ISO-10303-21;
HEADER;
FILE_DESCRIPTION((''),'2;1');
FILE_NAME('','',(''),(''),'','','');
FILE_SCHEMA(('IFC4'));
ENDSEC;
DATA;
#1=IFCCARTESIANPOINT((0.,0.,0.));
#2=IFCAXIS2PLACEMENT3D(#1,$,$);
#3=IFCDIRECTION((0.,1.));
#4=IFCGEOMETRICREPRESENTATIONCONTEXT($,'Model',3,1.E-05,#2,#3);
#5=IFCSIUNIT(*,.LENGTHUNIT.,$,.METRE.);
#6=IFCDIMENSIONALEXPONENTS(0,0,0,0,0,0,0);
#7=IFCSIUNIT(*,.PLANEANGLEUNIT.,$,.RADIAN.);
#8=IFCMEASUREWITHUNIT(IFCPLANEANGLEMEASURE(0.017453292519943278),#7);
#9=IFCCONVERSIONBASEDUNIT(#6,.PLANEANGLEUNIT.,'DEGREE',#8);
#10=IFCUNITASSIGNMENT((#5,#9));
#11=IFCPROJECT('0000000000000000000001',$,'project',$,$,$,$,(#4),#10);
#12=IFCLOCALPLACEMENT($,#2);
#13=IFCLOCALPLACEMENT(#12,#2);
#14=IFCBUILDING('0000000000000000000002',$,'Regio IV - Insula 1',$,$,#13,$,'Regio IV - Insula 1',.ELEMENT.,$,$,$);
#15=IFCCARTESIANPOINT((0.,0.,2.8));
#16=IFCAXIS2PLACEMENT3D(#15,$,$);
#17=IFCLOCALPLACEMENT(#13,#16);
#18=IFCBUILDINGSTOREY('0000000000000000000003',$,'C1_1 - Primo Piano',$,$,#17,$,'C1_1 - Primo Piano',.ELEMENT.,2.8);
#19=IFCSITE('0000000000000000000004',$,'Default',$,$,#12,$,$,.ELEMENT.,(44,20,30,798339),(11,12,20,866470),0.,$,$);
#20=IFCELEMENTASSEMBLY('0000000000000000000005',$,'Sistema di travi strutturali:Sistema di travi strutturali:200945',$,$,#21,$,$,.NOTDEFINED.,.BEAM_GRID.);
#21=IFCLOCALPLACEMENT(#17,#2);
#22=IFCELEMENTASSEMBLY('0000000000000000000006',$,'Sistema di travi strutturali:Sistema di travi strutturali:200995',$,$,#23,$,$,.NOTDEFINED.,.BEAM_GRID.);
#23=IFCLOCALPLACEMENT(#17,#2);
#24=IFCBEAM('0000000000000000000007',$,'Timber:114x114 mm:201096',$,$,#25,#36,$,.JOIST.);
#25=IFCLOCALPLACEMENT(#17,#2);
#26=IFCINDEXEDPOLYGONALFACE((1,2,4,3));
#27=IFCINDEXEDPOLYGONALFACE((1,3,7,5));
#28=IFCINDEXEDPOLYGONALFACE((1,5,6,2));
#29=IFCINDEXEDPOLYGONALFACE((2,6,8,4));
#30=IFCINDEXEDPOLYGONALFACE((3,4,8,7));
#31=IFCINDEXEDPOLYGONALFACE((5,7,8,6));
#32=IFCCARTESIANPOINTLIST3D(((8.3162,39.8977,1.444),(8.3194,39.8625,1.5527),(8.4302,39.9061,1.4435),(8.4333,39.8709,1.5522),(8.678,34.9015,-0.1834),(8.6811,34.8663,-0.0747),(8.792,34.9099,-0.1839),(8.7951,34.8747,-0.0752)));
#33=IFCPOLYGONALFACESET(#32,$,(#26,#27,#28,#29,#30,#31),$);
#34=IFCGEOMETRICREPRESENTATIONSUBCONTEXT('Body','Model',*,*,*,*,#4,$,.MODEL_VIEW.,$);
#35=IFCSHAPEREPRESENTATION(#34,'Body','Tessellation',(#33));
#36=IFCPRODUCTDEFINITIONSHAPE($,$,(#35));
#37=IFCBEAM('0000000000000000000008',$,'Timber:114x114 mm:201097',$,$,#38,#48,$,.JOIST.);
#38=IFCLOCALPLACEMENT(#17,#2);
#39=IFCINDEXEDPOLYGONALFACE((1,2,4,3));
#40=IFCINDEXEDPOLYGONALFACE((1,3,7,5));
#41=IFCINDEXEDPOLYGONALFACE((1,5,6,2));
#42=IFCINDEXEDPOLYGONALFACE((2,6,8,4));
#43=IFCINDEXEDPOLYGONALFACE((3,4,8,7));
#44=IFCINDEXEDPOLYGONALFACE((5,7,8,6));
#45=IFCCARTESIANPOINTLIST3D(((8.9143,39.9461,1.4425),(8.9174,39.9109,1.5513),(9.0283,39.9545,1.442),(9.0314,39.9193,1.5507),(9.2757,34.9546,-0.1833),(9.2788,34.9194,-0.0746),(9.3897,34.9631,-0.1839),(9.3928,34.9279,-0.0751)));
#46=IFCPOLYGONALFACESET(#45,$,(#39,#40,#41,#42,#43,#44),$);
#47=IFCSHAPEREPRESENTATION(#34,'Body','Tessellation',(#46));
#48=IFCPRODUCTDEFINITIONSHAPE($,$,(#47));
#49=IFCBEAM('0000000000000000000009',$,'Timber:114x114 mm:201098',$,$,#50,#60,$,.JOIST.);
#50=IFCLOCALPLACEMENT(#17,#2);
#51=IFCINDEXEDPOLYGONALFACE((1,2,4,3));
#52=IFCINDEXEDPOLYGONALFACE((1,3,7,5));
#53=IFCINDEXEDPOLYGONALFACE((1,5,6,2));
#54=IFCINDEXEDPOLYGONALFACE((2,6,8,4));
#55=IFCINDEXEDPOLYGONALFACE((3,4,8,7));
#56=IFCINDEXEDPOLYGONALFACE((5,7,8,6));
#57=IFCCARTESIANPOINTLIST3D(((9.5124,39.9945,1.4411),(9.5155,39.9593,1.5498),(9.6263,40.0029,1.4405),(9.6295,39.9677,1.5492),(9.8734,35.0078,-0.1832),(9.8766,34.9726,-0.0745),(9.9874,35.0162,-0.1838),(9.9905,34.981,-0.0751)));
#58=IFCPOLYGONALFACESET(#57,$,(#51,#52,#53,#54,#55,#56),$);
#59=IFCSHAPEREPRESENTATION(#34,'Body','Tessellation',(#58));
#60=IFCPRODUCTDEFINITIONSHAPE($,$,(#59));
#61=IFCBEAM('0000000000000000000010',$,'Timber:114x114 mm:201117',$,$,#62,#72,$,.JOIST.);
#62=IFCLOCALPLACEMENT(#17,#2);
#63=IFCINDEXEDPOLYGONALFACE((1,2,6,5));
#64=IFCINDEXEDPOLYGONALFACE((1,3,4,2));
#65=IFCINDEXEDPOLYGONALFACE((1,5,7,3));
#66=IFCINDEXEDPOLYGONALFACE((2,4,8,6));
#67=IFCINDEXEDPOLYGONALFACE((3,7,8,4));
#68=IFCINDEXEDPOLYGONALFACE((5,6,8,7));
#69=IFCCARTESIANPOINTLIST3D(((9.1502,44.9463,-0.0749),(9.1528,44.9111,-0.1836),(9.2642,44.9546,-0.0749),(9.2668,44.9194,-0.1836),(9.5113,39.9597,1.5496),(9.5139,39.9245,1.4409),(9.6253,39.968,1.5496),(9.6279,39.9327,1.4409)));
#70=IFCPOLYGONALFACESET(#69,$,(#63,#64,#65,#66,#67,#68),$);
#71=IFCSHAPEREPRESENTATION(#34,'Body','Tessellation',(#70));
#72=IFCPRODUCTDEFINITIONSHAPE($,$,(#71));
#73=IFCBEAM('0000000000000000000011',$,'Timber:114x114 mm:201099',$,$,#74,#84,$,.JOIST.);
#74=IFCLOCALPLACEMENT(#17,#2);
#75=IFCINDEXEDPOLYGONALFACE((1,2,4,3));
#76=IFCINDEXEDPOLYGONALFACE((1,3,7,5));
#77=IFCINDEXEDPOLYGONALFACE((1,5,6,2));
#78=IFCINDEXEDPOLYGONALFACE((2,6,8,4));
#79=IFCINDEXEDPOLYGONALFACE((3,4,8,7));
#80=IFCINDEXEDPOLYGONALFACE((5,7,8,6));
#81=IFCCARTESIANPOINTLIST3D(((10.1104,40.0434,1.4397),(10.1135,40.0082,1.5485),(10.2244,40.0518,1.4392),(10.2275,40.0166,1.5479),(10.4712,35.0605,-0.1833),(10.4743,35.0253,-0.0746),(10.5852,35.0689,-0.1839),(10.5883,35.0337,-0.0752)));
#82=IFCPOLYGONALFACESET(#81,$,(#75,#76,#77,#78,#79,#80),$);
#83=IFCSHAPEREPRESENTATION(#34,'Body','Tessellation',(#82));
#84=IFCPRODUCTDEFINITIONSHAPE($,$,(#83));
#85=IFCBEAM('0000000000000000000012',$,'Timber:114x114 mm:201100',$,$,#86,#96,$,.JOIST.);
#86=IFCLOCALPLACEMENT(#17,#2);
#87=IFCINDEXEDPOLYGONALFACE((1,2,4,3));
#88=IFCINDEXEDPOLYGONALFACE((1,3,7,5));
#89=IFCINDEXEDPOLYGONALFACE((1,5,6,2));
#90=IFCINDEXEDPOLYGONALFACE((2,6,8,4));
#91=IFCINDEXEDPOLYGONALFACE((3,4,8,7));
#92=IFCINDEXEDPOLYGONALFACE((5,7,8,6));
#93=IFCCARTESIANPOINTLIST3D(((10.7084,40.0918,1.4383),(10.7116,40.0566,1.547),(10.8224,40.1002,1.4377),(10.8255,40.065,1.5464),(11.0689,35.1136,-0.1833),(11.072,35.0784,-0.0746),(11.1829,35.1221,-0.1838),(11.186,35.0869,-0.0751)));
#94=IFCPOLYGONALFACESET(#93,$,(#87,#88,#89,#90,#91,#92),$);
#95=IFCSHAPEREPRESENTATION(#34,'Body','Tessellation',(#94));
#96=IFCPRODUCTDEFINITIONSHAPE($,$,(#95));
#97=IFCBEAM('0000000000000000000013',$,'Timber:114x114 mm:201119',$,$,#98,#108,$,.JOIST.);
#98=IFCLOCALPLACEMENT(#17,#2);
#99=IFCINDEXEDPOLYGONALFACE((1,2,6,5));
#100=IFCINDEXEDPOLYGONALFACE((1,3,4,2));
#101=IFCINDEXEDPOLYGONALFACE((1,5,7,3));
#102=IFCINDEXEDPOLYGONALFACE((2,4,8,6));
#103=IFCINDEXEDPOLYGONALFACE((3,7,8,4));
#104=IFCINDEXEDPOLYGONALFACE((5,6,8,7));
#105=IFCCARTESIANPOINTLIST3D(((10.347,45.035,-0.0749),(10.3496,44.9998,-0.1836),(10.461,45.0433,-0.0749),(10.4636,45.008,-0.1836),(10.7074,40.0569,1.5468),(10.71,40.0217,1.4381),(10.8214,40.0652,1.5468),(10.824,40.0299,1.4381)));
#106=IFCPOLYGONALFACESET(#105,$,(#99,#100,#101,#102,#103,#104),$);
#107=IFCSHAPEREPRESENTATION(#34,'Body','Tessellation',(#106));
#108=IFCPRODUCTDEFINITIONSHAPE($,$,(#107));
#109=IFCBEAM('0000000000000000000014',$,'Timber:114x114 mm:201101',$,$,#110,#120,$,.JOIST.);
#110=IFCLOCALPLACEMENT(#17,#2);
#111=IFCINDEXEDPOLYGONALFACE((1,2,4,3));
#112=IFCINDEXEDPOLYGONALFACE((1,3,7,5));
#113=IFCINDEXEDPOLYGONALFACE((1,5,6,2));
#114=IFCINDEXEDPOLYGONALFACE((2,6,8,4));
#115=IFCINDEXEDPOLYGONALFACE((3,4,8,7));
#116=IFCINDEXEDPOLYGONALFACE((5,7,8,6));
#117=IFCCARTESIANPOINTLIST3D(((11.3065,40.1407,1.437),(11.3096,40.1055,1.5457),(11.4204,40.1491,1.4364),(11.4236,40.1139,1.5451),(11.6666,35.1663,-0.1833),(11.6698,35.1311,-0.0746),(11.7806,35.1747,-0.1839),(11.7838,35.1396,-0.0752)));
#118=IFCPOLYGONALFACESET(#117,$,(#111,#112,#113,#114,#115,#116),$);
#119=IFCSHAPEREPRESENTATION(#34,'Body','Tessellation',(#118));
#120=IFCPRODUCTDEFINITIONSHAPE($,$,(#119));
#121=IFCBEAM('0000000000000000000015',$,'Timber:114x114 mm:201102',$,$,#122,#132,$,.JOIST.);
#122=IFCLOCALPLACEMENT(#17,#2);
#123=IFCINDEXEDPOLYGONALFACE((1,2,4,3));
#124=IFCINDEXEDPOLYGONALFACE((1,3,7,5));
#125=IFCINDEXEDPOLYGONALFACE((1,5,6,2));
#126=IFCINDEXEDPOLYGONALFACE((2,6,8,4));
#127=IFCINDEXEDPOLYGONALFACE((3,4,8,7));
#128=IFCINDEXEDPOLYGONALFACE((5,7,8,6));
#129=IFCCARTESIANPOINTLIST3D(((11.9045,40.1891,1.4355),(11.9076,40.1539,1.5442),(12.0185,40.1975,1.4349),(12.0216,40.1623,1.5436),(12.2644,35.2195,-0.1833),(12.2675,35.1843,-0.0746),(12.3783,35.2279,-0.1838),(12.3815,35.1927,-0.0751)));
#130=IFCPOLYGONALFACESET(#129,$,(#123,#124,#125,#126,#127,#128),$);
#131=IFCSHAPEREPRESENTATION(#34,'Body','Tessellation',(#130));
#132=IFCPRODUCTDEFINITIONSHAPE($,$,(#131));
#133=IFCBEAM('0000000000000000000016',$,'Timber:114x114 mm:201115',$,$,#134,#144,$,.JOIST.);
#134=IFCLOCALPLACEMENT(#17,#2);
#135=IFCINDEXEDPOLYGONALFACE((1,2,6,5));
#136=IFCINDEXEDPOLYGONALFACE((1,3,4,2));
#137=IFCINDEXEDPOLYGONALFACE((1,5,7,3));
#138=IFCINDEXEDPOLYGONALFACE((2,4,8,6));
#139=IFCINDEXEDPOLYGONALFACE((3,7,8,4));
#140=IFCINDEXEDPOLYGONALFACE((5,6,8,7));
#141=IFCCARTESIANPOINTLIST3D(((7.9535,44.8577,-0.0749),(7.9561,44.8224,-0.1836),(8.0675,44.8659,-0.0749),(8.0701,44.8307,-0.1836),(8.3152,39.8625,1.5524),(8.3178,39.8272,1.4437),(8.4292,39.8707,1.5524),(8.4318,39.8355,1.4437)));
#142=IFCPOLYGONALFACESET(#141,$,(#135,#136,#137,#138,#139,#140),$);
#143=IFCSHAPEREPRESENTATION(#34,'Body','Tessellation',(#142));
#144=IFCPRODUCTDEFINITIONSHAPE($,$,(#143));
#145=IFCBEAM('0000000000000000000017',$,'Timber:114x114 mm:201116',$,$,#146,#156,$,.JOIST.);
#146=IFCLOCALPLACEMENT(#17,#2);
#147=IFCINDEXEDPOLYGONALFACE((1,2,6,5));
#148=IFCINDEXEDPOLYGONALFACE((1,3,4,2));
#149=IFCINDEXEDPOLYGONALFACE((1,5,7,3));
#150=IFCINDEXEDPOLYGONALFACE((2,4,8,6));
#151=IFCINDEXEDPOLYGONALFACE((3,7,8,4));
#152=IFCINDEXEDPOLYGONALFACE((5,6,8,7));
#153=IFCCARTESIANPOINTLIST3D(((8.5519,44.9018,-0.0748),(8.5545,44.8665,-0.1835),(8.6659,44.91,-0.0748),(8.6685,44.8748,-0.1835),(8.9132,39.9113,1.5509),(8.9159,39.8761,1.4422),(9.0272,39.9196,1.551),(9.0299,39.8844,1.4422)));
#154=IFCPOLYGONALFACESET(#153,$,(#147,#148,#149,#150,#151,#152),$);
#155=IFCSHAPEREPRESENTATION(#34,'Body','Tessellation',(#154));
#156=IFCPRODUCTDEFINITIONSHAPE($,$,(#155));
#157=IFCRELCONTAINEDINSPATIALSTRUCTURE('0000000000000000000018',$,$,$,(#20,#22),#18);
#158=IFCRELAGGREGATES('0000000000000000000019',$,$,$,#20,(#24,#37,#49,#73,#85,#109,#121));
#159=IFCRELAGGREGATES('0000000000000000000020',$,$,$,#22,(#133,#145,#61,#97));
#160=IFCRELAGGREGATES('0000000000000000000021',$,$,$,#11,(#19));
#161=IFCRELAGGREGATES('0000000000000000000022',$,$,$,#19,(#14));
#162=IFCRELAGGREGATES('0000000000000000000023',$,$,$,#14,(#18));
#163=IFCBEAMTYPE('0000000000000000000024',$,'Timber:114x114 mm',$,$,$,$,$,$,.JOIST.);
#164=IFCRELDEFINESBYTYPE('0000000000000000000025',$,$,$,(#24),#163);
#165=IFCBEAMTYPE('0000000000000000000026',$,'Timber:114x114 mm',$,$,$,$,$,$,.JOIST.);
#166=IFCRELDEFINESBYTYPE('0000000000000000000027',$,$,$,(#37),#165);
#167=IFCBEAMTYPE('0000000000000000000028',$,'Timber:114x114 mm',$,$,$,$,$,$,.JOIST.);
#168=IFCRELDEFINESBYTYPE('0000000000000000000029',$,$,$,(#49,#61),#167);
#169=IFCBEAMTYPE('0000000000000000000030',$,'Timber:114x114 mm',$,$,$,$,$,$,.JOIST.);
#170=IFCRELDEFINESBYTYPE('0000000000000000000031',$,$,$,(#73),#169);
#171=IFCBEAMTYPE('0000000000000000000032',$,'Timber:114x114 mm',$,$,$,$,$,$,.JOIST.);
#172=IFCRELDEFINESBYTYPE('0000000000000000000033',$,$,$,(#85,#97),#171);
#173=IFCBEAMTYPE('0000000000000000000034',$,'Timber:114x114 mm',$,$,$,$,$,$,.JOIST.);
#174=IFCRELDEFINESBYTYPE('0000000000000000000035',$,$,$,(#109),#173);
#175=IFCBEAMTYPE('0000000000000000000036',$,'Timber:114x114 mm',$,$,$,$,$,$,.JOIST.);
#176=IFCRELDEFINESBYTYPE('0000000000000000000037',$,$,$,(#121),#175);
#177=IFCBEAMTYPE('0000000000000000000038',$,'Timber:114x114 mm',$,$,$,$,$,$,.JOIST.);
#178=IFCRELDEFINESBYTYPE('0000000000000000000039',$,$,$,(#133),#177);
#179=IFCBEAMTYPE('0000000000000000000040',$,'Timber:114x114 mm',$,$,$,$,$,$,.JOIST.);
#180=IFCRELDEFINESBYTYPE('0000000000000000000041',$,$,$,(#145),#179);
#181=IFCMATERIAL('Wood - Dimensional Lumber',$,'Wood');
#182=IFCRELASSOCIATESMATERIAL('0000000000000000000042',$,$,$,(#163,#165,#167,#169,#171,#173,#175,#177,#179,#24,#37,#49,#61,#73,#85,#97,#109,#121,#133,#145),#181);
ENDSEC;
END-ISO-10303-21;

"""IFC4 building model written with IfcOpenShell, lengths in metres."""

from ifc_helpers import new_model, entity, si_unit, converted_unit, direction, frame, origin, origin_2d_with_axis, place, context, subcontext, project, spatial, rectangle, extrude, source, transform, mapped, material, material_profile, profile_set, profile_usage, type_object, type_shapes, element, aggregate, save


model = new_model("IFC4")

# Units and contexts
model_context = context("Model", 3, precision=1e-05, world=origin(), true_north=direction((0.0, 1.0)))
body_context = subcontext(model_context, "Body", "Model", "MODEL_VIEW")
ifc_project = project(units=[si_unit("LENGTHUNIT", "METRE"), converted_unit("PLANEANGLEUNIT", "DEGREE", entity("IfcPlaneAngleMeasure", 0.017453292519943278), si_unit("PLANEANGLEUNIT", "RADIAN"), dimensions=[0, 0, 0, 0, 0, 0, 0])], contexts=[model_context])

# Site, building, storey
site_placement = place(None, origin())
site = spatial("IfcSite", under=ifc_project, at=site_placement, Name="Default", CompositionType="ELEMENT", RefLatitude=(44, 20, 30, 798339), RefLongitude=(11, 12, 20, 866470), RefElevation=0.0)
building_placement = place(site_placement, origin())
building = spatial("IfcBuilding", under=site, at=building_placement, Name="Regio IV - Insula 1", LongName="Regio IV - Insula 1", CompositionType="ELEMENT")
storey_placement = place(building_placement, frame((0.0, 0.0, 2.8)))
storey = spatial("IfcBuildingStorey", under=building, at=storey_placement, Name="C1_1 - Primo Piano", LongName="C1_1 - Primo Piano", CompositionType="ELEMENT", Elevation=2.8)

# Element assembly
assembly_1_placement = place(storey_placement, origin())
assembly_1 = element("IfcElementAssembly", 1, at=assembly_1_placement, inside=storey, Name="Sistema di travi strutturali:Sistema di travi strutturali:200945", AssemblyPlace="NOTDEFINED", PredefinedType="BEAM_GRID")
ifc_material = material(Name="Wood - Dimensional Lumber", Category="Wood")
ifc_material_profile = material_profile(ifc_material, rectangle(XDim=5.294, YDim=0.1143, at=origin_2d_with_axis()), Name="114x114 mm")
ifc_profile_set = profile_set([ifc_material_profile], Name="114x114 mm")
ifc_profile_usage = profile_usage(ifc_profile_set, cardinal=8)

# Element assembly
assembly_2_placement = place(storey_placement, origin())
assembly_2 = element("IfcElementAssembly", 2, at=assembly_2_placement, inside=storey, Name="Sistema di travi strutturali:Sistema di travi strutturali:200995", AssemblyPlace="NOTDEFINED", PredefinedType="BEAM_GRID")

# Beams
beam_type_1 = type_object("IfcBeamType", Name="Timber:114x114 mm", PredefinedType="JOIST", material=ifc_profile_set)
shared_shape_1 = source(origin(), body_context, "Body", "SweptSolid", [
    extrude(rectangle(XDim=5.267, YDim=0.1143, at=origin_2d_with_axis()), frame((0.0, 0.0, -0.0572), z_axis=(0.0, 0.0, 1.0), x_axis=(-1.0, 0.0, 0.0)), (0.0, 0.0, 1.0), 0.1143),
])
type_shapes(beam_type_1, [shared_shape_1])
beam_1_placement = place(assembly_1_placement, frame((8.5557, 37.3862, 0.6844), z_axis=(0.027263, -0.307812, 0.951057), x_axis=(0.068686, -0.948585, -0.308981)))
beam_1 = element("IfcBeam", 3, at=beam_1_placement, type_object=beam_type_1, material=ifc_profile_usage, Name="Timber:114x114 mm:201096", PredefinedType="JOIST", context=body_context, shape_type="MappedRepresentation", body=[
    mapped(shared_shape_1, transform((0.0, 0.0, 0.0), scale=1.0)),
])
beam_type_2 = type_object("IfcBeamType", Name="Timber:114x114 mm", PredefinedType="JOIST", material=ifc_profile_set)
shared_shape_2 = source(origin(), body_context, "Body", "SweptSolid", [
    extrude(rectangle(XDim=5.262, YDim=0.1143, at=origin_2d_with_axis()), frame((0.0, 0.0, -0.0572), z_axis=(0.0, 0.0, 1.0), x_axis=(-1.0, 0.0, 0.0)), (0.0, 0.0, 1.0), 0.1143),
])
type_shapes(beam_type_2, [shared_shape_2])
beam_2_placement = place(assembly_1_placement, frame((9.1536, 37.437, 0.6837), z_axis=(0.027263, -0.307812, 0.951057), x_axis=(0.068686, -0.948585, -0.308981)))
beam_2 = element("IfcBeam", 4, at=beam_2_placement, type_object=beam_type_2, material=ifc_profile_usage, Name="Timber:114x114 mm:201097", PredefinedType="JOIST", context=body_context, shape_type="MappedRepresentation", body=[
    mapped(shared_shape_2, transform((0.0, 0.0, 0.0), scale=1.0)),
])
beam_type_3 = type_object("IfcBeamType", Name="Timber:114x114 mm", PredefinedType="JOIST", material=ifc_profile_set)
shared_shape_3 = source(origin(), body_context, "Body", "SweptSolid", [
    extrude(rectangle(XDim=5.257, YDim=0.1143, at=origin_2d_with_axis()), frame((0.0, 0.0, -0.0572), z_axis=(0.0, 0.0, 1.0), x_axis=(-1.0, 0.0, 0.0)), (0.0, 0.0, 1.0), 0.1143),
])
type_shapes(beam_type_3, [shared_shape_3])
beam_3_placement = place(assembly_1_placement, frame((9.7514, 37.4878, 0.683), z_axis=(0.027263, -0.307812, 0.951057), x_axis=(0.068686, -0.948585, -0.308981)))
beam_3 = element("IfcBeam", 5, at=beam_3_placement, type_object=beam_type_3, material=ifc_profile_usage, Name="Timber:114x114 mm:201098", PredefinedType="JOIST", context=body_context, shape_type="MappedRepresentation", body=[
    mapped(shared_shape_3, transform((0.0, 0.0, 0.0), scale=1.0)),
])
beam_4_placement = place(assembly_2_placement, frame((9.3891, 42.4395, 0.683), z_axis=(-0.022823, 0.308173, 0.951057), x_axis=(0.068685, -0.948573, 0.309017)))
beam_4 = element("IfcBeam", 6, at=beam_4_placement, type_object=beam_type_3, material=ifc_profile_usage, Name="Timber:114x114 mm:201117", PredefinedType="JOIST", context=body_context, shape_type="MappedRepresentation", body=[
    mapped(shared_shape_3, transform((0.0, 0.0, 0.0), scale=1.0)),
])
beam_type_4 = type_object("IfcBeamType", Name="Timber:114x114 mm", PredefinedType="JOIST", material=ifc_profile_set)
shared_shape_4 = source(origin(), body_context, "Body", "SweptSolid", [
    extrude(rectangle(XDim=5.253, YDim=0.1143, at=origin_2d_with_axis()), frame((0.0, 0.0, -0.0572), z_axis=(0.0, 0.0, 1.0), x_axis=(-1.0, 0.0, 0.0)), (0.0, 0.0, 1.0), 0.1143),
])
type_shapes(beam_type_4, [shared_shape_4])
beam_5_placement = place(assembly_1_placement, frame((10.3493, 37.5385, 0.6823), z_axis=(0.027263, -0.307812, 0.951057), x_axis=(0.068686, -0.948585, -0.308981)))
beam_5 = element("IfcBeam", 7, at=beam_5_placement, type_object=beam_type_4, material=ifc_profile_usage, Name="Timber:114x114 mm:201099", PredefinedType="JOIST", context=body_context, shape_type="MappedRepresentation", body=[
    mapped(shared_shape_4, transform((0.0, 0.0, 0.0), scale=1.0)),
])
beam_type_5 = type_object("IfcBeamType", Name="Timber:114x114 mm", PredefinedType="JOIST", material=ifc_profile_set)
shared_shape_5 = source(origin(), body_context, "Body", "SweptSolid", [
    extrude(rectangle(XDim=5.248, YDim=0.1143, at=origin_2d_with_axis()), frame((0.0, 0.0, -0.0572), z_axis=(0.0, 0.0, 1.0), x_axis=(-1.0, 0.0, 0.0)), (0.0, 0.0, 1.0), 0.1143),
])
type_shapes(beam_type_5, [shared_shape_5])
beam_6_placement = place(assembly_1_placement, frame((10.9472, 37.5893, 0.6816), z_axis=(0.027263, -0.307812, 0.951057), x_axis=(0.068686, -0.948585, -0.308981)))
beam_6 = element("IfcBeam", 8, at=beam_6_placement, type_object=beam_type_5, material=ifc_profile_usage, Name="Timber:114x114 mm:201100", PredefinedType="JOIST", context=body_context, shape_type="MappedRepresentation", body=[
    mapped(shared_shape_5, transform((0.0, 0.0, 0.0), scale=1.0)),
])
beam_7_placement = place(assembly_2_placement, frame((10.5855, 42.5325, 0.6816), z_axis=(-0.022823, 0.308173, 0.951057), x_axis=(0.068685, -0.948573, 0.309017)))
beam_7 = element("IfcBeam", 9, at=beam_7_placement, type_object=beam_type_5, material=ifc_profile_usage, Name="Timber:114x114 mm:201119", PredefinedType="JOIST", context=body_context, shape_type="MappedRepresentation", body=[
    mapped(shared_shape_5, transform((0.0, 0.0, 0.0), scale=1.0)),
])
beam_type_6 = type_object("IfcBeamType", Name="Timber:114x114 mm", PredefinedType="JOIST", material=ifc_profile_set)
shared_shape_6 = source(origin(), body_context, "Body", "SweptSolid", [
    extrude(rectangle(XDim=5.244, YDim=0.1143, at=origin_2d_with_axis()), frame((0.0, 0.0, -0.0572), z_axis=(0.0, 0.0, 1.0), x_axis=(-1.0, 0.0, 0.0)), (0.0, 0.0, 1.0), 0.1143),
])
type_shapes(beam_type_6, [shared_shape_6])
beam_8_placement = place(assembly_1_placement, frame((11.5451, 37.6401, 0.6809), z_axis=(0.027263, -0.307812, 0.951057), x_axis=(0.068686, -0.948585, -0.308981)))
beam_8 = element("IfcBeam", 10, at=beam_8_placement, type_object=beam_type_6, material=ifc_profile_usage, Name="Timber:114x114 mm:201101", PredefinedType="JOIST", context=body_context, shape_type="MappedRepresentation", body=[
    mapped(shared_shape_6, transform((0.0, 0.0, 0.0), scale=1.0)),
])
beam_type_7 = type_object("IfcBeamType", Name="Timber:114x114 mm", PredefinedType="JOIST", material=ifc_profile_set)
shared_shape_7 = source(origin(), body_context, "Body", "SweptSolid", [
    extrude(rectangle(XDim=5.239, YDim=0.1143, at=origin_2d_with_axis()), frame((0.0, 0.0, -0.0572), z_axis=(0.0, 0.0, 1.0), x_axis=(-1.0, 0.0, 0.0)), (0.0, 0.0, 1.0), 0.1143),
])
type_shapes(beam_type_7, [shared_shape_7])
beam_9_placement = place(assembly_1_placement, frame((12.143, 37.6909, 0.6802), z_axis=(0.027263, -0.307812, 0.951057), x_axis=(0.068686, -0.948585, -0.308981)))
beam_9 = element("IfcBeam", 11, at=beam_9_placement, type_object=beam_type_7, material=ifc_profile_usage, Name="Timber:114x114 mm:201102", PredefinedType="JOIST", context=body_context, shape_type="MappedRepresentation", body=[
    mapped(shared_shape_7, transform((0.0, 0.0, 0.0), scale=1.0)),
])
aggregate(assembly_1, [beam_1, beam_2, beam_3, beam_5, beam_6, beam_8, beam_9])
beam_type_8 = type_object("IfcBeamType", Name="Timber:114x114 mm", PredefinedType="JOIST", material=ifc_profile_set)
shared_shape_8 = source(origin(), body_context, "Body", "SweptSolid", [
    extrude(rectangle(XDim=5.266, YDim=0.1143, at=origin_2d_with_axis()), frame((0.0, 0.0, -0.0572), z_axis=(0.0, 0.0, 1.0), x_axis=(-1.0, 0.0, 0.0)), (0.0, 0.0, 1.0), 0.1143),
])
type_shapes(beam_type_8, [shared_shape_8])
beam_10_placement = place(assembly_2_placement, frame((8.1927, 42.3466, 0.6844), z_axis=(-0.022823, 0.308173, 0.951057), x_axis=(0.068685, -0.948573, 0.309017)))
beam_10 = element("IfcBeam", 12, at=beam_10_placement, type_object=beam_type_8, material=ifc_profile_usage, Name="Timber:114x114 mm:201115", PredefinedType="JOIST", context=body_context, shape_type="MappedRepresentation", body=[
    mapped(shared_shape_8, transform((0.0, 0.0, 0.0), scale=1.0)),
])
beam_type_9 = type_object("IfcBeamType", Name="Timber:114x114 mm", PredefinedType="JOIST", material=ifc_profile_set)
shared_shape_9 = source(origin(), body_context, "Body", "SweptSolid", [
    extrude(rectangle(XDim=5.261, YDim=0.1143, at=origin_2d_with_axis()), frame((0.0, 0.0, -0.0572), z_axis=(0.0, 0.0, 1.0), x_axis=(-1.0, 0.0, 0.0)), (0.0, 0.0, 1.0), 0.1143),
])
type_shapes(beam_type_9, [shared_shape_9])
beam_11_placement = place(assembly_2_placement, frame((8.7909, 42.3931, 0.6837), z_axis=(-0.022823, 0.308173, 0.951057), x_axis=(0.068685, -0.948573, 0.309017)))
beam_11 = element("IfcBeam", 13, at=beam_11_placement, type_object=beam_type_9, material=ifc_profile_usage, Name="Timber:114x114 mm:201116", PredefinedType="JOIST", context=body_context, shape_type="MappedRepresentation", body=[
    mapped(shared_shape_9, transform((0.0, 0.0, 0.0), scale=1.0)),
])
aggregate(assembly_2, [beam_10, beam_11, beam_4, beam_7])

save(model, "model.ifc")
